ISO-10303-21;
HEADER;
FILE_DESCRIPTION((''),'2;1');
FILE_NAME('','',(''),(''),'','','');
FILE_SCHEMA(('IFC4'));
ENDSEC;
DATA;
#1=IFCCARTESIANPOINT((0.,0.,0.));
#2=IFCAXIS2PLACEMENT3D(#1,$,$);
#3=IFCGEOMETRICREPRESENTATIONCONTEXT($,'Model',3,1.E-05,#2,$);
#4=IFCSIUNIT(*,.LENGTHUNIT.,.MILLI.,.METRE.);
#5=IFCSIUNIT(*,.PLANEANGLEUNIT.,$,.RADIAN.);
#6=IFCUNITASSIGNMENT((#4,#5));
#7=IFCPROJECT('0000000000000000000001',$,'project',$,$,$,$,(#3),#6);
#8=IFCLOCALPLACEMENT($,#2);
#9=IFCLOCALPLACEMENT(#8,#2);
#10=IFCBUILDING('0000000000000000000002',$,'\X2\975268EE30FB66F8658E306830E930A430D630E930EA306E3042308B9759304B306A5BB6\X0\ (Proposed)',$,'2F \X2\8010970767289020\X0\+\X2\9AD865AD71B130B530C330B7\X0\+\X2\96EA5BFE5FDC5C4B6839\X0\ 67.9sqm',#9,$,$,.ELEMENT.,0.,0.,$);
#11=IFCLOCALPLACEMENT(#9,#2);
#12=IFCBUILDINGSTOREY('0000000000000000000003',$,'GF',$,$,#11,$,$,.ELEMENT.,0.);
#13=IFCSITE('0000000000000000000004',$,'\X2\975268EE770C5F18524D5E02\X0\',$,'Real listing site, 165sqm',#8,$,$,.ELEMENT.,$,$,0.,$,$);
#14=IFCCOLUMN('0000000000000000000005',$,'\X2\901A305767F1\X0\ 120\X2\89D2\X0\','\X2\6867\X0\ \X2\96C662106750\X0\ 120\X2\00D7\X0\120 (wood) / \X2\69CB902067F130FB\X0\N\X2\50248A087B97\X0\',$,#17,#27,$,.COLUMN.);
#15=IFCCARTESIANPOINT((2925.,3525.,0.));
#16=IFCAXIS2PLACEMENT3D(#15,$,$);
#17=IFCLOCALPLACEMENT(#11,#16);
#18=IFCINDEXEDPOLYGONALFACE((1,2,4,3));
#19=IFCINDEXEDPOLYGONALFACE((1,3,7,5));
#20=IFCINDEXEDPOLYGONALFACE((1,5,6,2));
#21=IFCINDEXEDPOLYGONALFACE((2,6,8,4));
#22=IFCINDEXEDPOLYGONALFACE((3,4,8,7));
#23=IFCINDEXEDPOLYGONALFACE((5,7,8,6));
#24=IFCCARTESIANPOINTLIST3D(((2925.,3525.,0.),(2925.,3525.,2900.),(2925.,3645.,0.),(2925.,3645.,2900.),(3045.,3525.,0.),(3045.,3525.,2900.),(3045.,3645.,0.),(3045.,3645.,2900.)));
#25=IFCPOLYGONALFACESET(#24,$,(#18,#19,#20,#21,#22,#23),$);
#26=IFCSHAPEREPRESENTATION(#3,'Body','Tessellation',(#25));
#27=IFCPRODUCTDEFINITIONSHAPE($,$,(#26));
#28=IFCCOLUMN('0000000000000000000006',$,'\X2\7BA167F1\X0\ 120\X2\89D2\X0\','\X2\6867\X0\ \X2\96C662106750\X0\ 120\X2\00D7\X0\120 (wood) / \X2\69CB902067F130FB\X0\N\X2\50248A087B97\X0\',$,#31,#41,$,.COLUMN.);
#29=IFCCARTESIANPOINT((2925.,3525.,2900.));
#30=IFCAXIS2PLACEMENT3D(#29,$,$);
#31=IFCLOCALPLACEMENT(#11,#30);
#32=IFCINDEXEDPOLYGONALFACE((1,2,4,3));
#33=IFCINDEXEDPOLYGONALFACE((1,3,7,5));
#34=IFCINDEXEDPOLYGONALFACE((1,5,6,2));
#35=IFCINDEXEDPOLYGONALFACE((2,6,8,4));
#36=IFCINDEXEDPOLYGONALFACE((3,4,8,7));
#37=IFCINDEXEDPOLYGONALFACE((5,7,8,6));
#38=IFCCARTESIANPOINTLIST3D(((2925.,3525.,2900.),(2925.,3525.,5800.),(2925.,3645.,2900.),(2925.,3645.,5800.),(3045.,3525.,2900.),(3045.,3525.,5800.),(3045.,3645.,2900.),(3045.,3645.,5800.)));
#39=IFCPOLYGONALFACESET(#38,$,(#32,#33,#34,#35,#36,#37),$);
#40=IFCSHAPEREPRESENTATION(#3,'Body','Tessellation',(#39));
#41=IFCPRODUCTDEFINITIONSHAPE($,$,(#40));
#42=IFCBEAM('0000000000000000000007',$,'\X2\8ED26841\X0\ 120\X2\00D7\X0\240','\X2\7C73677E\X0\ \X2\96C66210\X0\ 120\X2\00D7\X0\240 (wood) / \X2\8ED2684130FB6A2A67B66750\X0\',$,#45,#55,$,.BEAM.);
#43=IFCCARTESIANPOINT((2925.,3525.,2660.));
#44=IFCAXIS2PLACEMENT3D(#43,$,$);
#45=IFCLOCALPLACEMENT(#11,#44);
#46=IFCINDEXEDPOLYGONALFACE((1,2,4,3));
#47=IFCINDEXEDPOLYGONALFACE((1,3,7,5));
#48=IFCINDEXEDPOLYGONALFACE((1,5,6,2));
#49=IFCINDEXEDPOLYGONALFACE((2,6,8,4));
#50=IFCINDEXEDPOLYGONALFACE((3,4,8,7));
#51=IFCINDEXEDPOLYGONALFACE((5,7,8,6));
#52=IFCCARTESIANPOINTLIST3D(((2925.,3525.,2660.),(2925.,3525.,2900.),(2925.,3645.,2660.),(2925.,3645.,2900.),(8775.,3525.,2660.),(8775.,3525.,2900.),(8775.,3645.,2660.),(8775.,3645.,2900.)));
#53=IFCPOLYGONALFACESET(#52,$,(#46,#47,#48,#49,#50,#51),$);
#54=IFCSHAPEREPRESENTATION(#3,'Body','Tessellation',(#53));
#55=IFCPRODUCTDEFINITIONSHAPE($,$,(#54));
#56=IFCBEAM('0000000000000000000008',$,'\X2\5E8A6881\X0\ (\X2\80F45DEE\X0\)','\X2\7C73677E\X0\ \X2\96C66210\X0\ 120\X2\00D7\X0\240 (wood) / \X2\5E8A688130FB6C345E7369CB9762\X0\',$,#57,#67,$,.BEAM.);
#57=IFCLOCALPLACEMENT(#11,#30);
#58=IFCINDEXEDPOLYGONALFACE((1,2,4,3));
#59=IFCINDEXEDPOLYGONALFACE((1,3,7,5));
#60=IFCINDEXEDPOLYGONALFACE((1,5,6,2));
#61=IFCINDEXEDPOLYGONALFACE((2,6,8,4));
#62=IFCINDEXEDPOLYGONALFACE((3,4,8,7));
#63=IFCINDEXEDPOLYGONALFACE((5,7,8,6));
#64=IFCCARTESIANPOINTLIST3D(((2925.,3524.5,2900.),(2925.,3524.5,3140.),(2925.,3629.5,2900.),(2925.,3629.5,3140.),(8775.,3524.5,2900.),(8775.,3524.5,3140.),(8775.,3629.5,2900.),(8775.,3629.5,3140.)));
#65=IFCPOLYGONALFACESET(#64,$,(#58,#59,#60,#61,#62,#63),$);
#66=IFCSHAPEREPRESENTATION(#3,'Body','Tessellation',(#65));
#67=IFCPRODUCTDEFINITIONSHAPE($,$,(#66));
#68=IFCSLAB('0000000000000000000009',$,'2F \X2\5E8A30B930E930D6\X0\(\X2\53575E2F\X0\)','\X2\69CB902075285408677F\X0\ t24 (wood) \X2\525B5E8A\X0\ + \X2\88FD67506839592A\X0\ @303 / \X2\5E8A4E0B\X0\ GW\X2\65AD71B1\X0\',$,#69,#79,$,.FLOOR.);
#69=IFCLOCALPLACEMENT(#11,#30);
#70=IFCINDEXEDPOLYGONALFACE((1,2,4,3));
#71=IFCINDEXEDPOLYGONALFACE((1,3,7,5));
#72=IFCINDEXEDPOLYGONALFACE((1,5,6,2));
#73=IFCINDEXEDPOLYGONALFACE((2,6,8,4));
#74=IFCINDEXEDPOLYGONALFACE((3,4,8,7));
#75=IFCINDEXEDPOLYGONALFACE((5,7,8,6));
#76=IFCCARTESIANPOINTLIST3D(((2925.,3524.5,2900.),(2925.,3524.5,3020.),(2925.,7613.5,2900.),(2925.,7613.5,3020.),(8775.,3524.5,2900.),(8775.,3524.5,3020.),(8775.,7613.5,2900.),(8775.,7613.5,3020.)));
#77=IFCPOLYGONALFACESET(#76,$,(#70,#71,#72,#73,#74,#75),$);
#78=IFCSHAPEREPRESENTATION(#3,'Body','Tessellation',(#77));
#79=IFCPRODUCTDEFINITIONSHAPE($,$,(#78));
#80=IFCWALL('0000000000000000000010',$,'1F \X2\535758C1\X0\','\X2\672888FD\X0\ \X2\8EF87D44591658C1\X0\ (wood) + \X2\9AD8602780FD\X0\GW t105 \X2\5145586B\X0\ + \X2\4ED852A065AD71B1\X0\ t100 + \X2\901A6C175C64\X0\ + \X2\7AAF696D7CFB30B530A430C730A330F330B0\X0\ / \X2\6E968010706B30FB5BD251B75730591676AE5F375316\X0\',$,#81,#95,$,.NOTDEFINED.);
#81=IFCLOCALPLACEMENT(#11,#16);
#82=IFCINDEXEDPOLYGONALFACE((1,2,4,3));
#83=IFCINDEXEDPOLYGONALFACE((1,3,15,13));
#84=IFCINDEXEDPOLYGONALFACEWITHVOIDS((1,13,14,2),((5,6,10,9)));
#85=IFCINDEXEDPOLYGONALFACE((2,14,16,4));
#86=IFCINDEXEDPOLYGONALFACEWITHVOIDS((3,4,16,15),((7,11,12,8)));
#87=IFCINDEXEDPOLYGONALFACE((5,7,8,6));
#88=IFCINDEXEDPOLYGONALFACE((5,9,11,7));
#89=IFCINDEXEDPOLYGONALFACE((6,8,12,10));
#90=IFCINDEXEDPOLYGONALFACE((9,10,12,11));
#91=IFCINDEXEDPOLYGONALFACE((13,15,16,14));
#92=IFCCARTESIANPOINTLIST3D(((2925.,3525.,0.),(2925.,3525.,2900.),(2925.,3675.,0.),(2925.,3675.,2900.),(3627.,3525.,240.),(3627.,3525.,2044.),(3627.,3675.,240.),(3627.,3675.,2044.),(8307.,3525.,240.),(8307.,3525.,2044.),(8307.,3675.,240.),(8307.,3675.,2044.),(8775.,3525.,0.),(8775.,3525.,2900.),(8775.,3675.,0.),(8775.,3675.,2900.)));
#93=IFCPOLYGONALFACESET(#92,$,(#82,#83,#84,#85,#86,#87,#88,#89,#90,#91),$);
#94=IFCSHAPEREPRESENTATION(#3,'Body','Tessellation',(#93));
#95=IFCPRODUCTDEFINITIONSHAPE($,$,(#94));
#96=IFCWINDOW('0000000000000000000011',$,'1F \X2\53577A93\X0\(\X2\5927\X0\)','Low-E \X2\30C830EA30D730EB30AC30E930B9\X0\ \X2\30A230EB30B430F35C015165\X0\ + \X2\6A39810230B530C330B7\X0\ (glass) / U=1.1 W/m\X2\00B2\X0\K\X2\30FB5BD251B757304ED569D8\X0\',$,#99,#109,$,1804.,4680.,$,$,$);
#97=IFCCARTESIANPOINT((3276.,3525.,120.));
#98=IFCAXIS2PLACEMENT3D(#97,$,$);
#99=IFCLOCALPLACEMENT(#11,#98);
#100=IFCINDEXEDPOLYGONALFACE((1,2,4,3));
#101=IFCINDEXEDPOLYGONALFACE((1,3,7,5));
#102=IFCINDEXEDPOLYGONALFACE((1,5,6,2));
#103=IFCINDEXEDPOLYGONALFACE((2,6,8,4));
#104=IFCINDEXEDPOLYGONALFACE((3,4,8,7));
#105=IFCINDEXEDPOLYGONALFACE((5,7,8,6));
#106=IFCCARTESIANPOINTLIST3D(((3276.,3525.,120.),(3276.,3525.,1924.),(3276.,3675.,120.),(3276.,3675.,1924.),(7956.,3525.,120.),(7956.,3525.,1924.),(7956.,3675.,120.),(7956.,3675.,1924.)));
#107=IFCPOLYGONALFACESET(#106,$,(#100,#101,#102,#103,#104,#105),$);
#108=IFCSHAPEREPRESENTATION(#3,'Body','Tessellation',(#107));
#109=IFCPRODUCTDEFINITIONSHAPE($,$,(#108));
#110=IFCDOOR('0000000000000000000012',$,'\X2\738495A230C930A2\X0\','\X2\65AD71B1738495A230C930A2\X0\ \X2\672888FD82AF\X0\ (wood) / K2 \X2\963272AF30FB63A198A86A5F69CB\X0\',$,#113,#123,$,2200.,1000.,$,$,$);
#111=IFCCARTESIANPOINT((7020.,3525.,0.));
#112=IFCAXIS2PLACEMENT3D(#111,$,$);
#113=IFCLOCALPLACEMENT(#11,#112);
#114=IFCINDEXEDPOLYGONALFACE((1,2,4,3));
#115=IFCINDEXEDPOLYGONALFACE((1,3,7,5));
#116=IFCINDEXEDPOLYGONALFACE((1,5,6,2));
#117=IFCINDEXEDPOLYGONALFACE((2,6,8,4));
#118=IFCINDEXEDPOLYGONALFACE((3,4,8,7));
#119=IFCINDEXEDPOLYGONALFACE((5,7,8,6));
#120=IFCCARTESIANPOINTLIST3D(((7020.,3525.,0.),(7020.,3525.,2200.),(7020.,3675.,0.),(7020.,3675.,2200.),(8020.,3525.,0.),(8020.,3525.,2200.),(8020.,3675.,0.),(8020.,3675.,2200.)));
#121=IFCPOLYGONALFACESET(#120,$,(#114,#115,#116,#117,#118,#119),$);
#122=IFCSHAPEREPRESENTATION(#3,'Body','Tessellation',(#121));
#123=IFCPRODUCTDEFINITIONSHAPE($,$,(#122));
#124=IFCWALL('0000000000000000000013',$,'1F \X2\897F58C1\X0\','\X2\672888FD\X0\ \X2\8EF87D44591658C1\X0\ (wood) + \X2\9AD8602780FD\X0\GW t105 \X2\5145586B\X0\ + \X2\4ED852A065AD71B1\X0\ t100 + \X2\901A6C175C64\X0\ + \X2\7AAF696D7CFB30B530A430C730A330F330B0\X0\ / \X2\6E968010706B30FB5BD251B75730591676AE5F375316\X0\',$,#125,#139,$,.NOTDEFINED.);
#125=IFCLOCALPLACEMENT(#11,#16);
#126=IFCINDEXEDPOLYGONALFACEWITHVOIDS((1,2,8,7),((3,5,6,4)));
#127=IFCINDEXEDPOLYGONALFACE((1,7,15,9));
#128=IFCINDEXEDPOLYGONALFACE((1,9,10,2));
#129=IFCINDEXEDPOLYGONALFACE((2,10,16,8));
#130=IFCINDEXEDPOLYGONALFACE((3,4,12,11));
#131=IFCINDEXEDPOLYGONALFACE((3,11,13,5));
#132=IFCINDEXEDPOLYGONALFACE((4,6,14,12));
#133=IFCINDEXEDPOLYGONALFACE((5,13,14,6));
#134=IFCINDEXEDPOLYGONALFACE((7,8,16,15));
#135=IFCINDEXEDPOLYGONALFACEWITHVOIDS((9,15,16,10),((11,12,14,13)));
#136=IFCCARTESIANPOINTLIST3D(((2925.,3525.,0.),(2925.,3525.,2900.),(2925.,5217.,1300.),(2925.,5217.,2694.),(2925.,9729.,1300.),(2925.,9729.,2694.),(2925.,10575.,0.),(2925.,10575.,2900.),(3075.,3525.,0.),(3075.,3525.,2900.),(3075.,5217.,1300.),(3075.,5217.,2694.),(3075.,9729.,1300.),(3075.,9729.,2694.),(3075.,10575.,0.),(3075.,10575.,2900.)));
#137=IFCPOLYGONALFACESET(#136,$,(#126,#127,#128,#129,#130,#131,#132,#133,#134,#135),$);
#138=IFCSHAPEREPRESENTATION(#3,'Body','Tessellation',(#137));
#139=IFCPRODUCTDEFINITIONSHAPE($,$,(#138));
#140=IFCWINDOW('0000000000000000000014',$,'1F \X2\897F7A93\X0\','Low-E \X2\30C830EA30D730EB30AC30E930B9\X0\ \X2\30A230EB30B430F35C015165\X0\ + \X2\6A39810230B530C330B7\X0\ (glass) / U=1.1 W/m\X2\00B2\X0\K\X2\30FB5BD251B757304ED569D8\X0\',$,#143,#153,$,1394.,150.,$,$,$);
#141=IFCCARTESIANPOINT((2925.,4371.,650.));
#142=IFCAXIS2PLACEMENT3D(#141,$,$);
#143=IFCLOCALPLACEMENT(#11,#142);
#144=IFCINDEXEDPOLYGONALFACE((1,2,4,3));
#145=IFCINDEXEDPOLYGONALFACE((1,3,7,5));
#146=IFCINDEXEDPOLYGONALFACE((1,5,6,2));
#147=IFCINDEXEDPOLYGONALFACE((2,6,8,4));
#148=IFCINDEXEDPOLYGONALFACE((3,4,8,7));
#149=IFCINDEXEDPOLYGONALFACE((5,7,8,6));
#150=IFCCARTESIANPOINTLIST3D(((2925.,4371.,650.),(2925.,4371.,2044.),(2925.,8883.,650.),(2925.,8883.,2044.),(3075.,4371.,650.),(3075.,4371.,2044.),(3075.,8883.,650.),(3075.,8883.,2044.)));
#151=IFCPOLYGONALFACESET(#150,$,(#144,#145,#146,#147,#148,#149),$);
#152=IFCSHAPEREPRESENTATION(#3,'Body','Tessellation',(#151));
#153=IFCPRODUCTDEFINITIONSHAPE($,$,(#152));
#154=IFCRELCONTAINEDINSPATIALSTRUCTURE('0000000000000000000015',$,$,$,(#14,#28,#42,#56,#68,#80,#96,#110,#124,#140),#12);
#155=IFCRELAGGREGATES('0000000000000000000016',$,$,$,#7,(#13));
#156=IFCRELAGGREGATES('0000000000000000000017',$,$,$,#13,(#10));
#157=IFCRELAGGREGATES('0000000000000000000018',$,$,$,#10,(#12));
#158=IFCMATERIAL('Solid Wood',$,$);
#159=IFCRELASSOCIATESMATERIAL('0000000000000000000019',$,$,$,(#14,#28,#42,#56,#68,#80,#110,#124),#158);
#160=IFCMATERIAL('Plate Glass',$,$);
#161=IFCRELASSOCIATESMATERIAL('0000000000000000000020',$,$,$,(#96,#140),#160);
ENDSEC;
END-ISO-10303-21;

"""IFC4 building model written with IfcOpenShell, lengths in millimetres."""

from ifc_helpers import new_model, si_unit, frame, frame_2d, origin, place, context, project, spatial, rectangle, extrude, material, element, fill, save


model = new_model("IFC4")

# Units and contexts
model_context = context("Model", 3, precision=1e-05, world=origin())
ifc_project = project(units=[si_unit("LENGTHUNIT", "METRE", prefix="MILLI"), si_unit("PLANEANGLEUNIT", "RADIAN")], contexts=[model_context])

# Site, building, storey
site_placement = place(None, origin())
site = spatial("IfcSite", under=ifc_project, at=site_placement, Name="青森県弘前市", ObjectType="Real listing site, 165sqm", CompositionType="ELEMENT", RefElevation=0.0)
building_placement = place(site_placement, origin())
building = spatial("IfcBuilding", under=site, at=building_placement, Name="青森・書斎とライブラリのある静かな家 (Proposed)", ObjectType="2F 耐震木造+高断熱サッシ+雪対応屋根 67.9sqm", CompositionType="ELEMENT", ElevationOfRefHeight=0.0, ElevationOfTerrain=0.0)
storey_placement = place(building_placement, origin())
storey = spatial("IfcBuildingStorey", under=building, at=storey_placement, Name="GF", CompositionType="ELEMENT", Elevation=0.0)

# Columns
ifc_material_1 = material(Name="Solid Wood")
column_1_placement = place(storey_placement, frame((2925.0, 3525.0, 0.0)))
element("IfcColumn", 1, at=column_1_placement, inside=storey, material=ifc_material_1, Name="通し柱 120角", Description="桧 集成材 120×120 (wood) / 構造柱・N値計算", PredefinedType="COLUMN", context=model_context, shape_type="SweptSolid", body=[
    extrude(rectangle(XDim=120.0, YDim=120.0, at=frame_2d((60.0, 60.0))), frame((2925.0, 3525.0, 0.0)), (0.0, 0.0, 1.0), 2900.0),
])
column_2_placement = place(storey_placement, frame((2925.0, 3525.0, 2900.0)))
element("IfcColumn", 2, at=column_2_placement, inside=storey, material=ifc_material_1, Name="管柱 120角", Description="桧 集成材 120×120 (wood) / 構造柱・N値計算", PredefinedType="COLUMN", context=model_context, shape_type="SweptSolid", body=[
    extrude(rectangle(XDim=120.0, YDim=120.0, at=frame_2d((60.0, 60.0))), frame((2925.0, 3525.0, 2900.0)), (0.0, 0.0, 1.0), 2900.0),
])

# Beams
beam_1_placement = place(storey_placement, frame((2925.0, 3525.0, 2660.0)))
element("IfcBeam", 3, at=beam_1_placement, inside=storey, material=ifc_material_1, Name="軒桁 120×240", Description="米松 集成 120×240 (wood) / 軒桁・横架材", PredefinedType="BEAM", context=model_context, shape_type="SweptSolid", body=[
    extrude(rectangle(XDim=5850.0, YDim=120.0, at=frame_2d((2925.0, 60.0))), frame((2925.0, 3525.0, 2660.0)), (0.0, 0.0, 1.0), 240.0),
])
beam_2_placement = place(storey_placement, frame((2925.0, 3525.0, 2900.0)))
element("IfcBeam", 4, at=beam_2_placement, inside=storey, material=ifc_material_1, Name="床梁 (胴差)", Description="米松 集成 120×240 (wood) / 床梁・水平構面", PredefinedType="BEAM", context=model_context, shape_type="SweptSolid", body=[
    extrude(rectangle(XDim=5850.0, YDim=105.0, at=frame_2d((2925.0, 52.0))), frame((2925.0, 3525.0, 2900.0)), (0.0, 0.0, 1.0), 240.0),
])

# Slab
slab_1_placement = place(storey_placement, frame((2925.0, 3525.0, 2900.0)))
element("IfcSlab", 5, at=slab_1_placement, inside=storey, material=ifc_material_1, Name="2F 床スラブ(南帯)", Description="構造用合板 t24 (wood) 剛床 + 製材根太 @303 / 床下 GW断熱", PredefinedType="FLOOR", context=model_context, shape_type="SweptSolid", body=[
    extrude(rectangle(XDim=5850.0, YDim=4089.0, at=frame_2d((2925.0, 2044.0))), frame((2925.0, 3525.0, 2900.0)), (0.0, 0.0, 1.0), 120.0),
])

# Wall, openings, window, door
wall_1_placement = place(storey_placement, frame((2925.0, 3525.0, 0.0)))
wall_1 = element("IfcWall", 6, at=wall_1_placement, inside=storey, material=ifc_material_1, Name="1F 南壁", Description="木製 軸組外壁 (wood) + 高性能GW t105 充填 + 付加断熱 t100 + 通気層 + 窯業系サイディング / 準耐火・寒冷地外皮強化", PredefinedType="NOTDEFINED", context=model_context, shape_type="SweptSolid", body=[
    extrude(rectangle(XDim=5850.0, YDim=150.0, at=frame_2d((2925.0, 75.0))), frame((2925.0, 3525.0, 0.0)), (0.0, 0.0, 1.0), 2900.0),
])
opening_1_placement = place(storey_placement, frame((3276.0, 3525.0, 120.0)))
opening_1 = element("IfcOpeningElement", 7, at=opening_1_placement, cuts=wall_1, PredefinedType="NOTDEFINED", context=model_context, shape_type="SweptSolid", body=[
    extrude(rectangle(XDim=4680.0, YDim=150.0, at=frame_2d((2340.0, 75.0))), frame((3276.0, 3525.0, 120.0)), (0.0, 0.0, 1.0), 1804.0),
])
opening_2_placement = place(storey_placement, frame((7020.0, 3525.0, 0.0)))
opening_2 = element("IfcOpeningElement", 8, at=opening_2_placement, cuts=wall_1, PredefinedType="NOTDEFINED", context=model_context, shape_type="SweptSolid", body=[
    extrude(rectangle(XDim=1000.0, YDim=150.0, at=frame_2d((500.0, 75.0))), frame((7020.0, 3525.0, 0.0)), (0.0, 0.0, 1.0), 2200.0),
])
ifc_material_2 = material(Name="Plate Glass")
window_1_placement = place(storey_placement, frame((3276.0, 3525.0, 120.0)))
window_1 = element("IfcWindow", 9, at=window_1_placement, inside=storey, material=ifc_material_2, Name="1F 南窓(大)", Description="Low-E トリプルガラス アルゴン封入 + 樹脂サッシ (glass) / U=1.1 W/m²K・寒冷地仕様", OverallHeight=1804.0, OverallWidth=4680.0, context=model_context, shape_type="SweptSolid", body=[
    extrude(rectangle(XDim=4680.0, YDim=150.0, at=frame_2d((2340.0, 75.0))), frame((3276.0, 3525.0, 120.0)), (0.0, 0.0, 1.0), 1804.0),
])
fill(opening_1, window_1)
door_placement = place(storey_placement, frame((7020.0, 3525.0, 0.0)))
door = element("IfcDoor", 10, at=door_placement, inside=storey, material=ifc_material_1, Name="玄関ドア", Description="断熱玄関ドア 木製芯 (wood) / K2 防犯・採風機構", OverallHeight=2200.0, OverallWidth=1000.0, context=model_context, shape_type="SweptSolid", body=[
    extrude(rectangle(XDim=1000.0, YDim=150.0, at=frame_2d((500.0, 75.0))), frame((7020.0, 3525.0, 0.0)), (0.0, 0.0, 1.0), 2200.0),
])
fill(opening_2, door)

# Wall, opening, window
wall_2_placement = place(storey_placement, frame((2925.0, 3525.0, 0.0)))
wall_2 = element("IfcWall", 11, at=wall_2_placement, inside=storey, material=ifc_material_1, Name="1F 西壁", Description="木製 軸組外壁 (wood) + 高性能GW t105 充填 + 付加断熱 t100 + 通気層 + 窯業系サイディング / 準耐火・寒冷地外皮強化", PredefinedType="NOTDEFINED", context=model_context, shape_type="SweptSolid", body=[
    extrude(rectangle(XDim=150.0, YDim=7050.0, at=frame_2d((75.0, 3525.0))), frame((2925.0, 3525.0, 0.0)), (0.0, 0.0, 1.0), 2900.0),
])
opening_3_placement = place(storey_placement, frame((2925.0, 4371.0, 650.0)))
opening_3 = element("IfcOpeningElement", 12, at=opening_3_placement, cuts=wall_2, PredefinedType="NOTDEFINED", context=model_context, shape_type="SweptSolid", body=[
    extrude(rectangle(XDim=150.0, YDim=4512.0, at=frame_2d((75.0, 2256.0))), frame((2925.0, 4371.0, 650.0)), (0.0, 0.0, 1.0), 1394.0),
])
window_2_placement = place(storey_placement, frame((2925.0, 4371.0, 650.0)))
window_2 = element("IfcWindow", 13, at=window_2_placement, inside=storey, material=ifc_material_2, Name="1F 西窓", Description="Low-E トリプルガラス アルゴン封入 + 樹脂サッシ (glass) / U=1.1 W/m²K・寒冷地仕様", OverallHeight=1394.0, OverallWidth=150.0, context=model_context, shape_type="SweptSolid", body=[
    extrude(rectangle(XDim=150.0, YDim=4512.0, at=frame_2d((75.0, 2256.0))), frame((2925.0, 4371.0, 650.0)), (0.0, 0.0, 1.0), 1394.0),
])
fill(opening_3, window_2)

save(model, "model.ifc")
